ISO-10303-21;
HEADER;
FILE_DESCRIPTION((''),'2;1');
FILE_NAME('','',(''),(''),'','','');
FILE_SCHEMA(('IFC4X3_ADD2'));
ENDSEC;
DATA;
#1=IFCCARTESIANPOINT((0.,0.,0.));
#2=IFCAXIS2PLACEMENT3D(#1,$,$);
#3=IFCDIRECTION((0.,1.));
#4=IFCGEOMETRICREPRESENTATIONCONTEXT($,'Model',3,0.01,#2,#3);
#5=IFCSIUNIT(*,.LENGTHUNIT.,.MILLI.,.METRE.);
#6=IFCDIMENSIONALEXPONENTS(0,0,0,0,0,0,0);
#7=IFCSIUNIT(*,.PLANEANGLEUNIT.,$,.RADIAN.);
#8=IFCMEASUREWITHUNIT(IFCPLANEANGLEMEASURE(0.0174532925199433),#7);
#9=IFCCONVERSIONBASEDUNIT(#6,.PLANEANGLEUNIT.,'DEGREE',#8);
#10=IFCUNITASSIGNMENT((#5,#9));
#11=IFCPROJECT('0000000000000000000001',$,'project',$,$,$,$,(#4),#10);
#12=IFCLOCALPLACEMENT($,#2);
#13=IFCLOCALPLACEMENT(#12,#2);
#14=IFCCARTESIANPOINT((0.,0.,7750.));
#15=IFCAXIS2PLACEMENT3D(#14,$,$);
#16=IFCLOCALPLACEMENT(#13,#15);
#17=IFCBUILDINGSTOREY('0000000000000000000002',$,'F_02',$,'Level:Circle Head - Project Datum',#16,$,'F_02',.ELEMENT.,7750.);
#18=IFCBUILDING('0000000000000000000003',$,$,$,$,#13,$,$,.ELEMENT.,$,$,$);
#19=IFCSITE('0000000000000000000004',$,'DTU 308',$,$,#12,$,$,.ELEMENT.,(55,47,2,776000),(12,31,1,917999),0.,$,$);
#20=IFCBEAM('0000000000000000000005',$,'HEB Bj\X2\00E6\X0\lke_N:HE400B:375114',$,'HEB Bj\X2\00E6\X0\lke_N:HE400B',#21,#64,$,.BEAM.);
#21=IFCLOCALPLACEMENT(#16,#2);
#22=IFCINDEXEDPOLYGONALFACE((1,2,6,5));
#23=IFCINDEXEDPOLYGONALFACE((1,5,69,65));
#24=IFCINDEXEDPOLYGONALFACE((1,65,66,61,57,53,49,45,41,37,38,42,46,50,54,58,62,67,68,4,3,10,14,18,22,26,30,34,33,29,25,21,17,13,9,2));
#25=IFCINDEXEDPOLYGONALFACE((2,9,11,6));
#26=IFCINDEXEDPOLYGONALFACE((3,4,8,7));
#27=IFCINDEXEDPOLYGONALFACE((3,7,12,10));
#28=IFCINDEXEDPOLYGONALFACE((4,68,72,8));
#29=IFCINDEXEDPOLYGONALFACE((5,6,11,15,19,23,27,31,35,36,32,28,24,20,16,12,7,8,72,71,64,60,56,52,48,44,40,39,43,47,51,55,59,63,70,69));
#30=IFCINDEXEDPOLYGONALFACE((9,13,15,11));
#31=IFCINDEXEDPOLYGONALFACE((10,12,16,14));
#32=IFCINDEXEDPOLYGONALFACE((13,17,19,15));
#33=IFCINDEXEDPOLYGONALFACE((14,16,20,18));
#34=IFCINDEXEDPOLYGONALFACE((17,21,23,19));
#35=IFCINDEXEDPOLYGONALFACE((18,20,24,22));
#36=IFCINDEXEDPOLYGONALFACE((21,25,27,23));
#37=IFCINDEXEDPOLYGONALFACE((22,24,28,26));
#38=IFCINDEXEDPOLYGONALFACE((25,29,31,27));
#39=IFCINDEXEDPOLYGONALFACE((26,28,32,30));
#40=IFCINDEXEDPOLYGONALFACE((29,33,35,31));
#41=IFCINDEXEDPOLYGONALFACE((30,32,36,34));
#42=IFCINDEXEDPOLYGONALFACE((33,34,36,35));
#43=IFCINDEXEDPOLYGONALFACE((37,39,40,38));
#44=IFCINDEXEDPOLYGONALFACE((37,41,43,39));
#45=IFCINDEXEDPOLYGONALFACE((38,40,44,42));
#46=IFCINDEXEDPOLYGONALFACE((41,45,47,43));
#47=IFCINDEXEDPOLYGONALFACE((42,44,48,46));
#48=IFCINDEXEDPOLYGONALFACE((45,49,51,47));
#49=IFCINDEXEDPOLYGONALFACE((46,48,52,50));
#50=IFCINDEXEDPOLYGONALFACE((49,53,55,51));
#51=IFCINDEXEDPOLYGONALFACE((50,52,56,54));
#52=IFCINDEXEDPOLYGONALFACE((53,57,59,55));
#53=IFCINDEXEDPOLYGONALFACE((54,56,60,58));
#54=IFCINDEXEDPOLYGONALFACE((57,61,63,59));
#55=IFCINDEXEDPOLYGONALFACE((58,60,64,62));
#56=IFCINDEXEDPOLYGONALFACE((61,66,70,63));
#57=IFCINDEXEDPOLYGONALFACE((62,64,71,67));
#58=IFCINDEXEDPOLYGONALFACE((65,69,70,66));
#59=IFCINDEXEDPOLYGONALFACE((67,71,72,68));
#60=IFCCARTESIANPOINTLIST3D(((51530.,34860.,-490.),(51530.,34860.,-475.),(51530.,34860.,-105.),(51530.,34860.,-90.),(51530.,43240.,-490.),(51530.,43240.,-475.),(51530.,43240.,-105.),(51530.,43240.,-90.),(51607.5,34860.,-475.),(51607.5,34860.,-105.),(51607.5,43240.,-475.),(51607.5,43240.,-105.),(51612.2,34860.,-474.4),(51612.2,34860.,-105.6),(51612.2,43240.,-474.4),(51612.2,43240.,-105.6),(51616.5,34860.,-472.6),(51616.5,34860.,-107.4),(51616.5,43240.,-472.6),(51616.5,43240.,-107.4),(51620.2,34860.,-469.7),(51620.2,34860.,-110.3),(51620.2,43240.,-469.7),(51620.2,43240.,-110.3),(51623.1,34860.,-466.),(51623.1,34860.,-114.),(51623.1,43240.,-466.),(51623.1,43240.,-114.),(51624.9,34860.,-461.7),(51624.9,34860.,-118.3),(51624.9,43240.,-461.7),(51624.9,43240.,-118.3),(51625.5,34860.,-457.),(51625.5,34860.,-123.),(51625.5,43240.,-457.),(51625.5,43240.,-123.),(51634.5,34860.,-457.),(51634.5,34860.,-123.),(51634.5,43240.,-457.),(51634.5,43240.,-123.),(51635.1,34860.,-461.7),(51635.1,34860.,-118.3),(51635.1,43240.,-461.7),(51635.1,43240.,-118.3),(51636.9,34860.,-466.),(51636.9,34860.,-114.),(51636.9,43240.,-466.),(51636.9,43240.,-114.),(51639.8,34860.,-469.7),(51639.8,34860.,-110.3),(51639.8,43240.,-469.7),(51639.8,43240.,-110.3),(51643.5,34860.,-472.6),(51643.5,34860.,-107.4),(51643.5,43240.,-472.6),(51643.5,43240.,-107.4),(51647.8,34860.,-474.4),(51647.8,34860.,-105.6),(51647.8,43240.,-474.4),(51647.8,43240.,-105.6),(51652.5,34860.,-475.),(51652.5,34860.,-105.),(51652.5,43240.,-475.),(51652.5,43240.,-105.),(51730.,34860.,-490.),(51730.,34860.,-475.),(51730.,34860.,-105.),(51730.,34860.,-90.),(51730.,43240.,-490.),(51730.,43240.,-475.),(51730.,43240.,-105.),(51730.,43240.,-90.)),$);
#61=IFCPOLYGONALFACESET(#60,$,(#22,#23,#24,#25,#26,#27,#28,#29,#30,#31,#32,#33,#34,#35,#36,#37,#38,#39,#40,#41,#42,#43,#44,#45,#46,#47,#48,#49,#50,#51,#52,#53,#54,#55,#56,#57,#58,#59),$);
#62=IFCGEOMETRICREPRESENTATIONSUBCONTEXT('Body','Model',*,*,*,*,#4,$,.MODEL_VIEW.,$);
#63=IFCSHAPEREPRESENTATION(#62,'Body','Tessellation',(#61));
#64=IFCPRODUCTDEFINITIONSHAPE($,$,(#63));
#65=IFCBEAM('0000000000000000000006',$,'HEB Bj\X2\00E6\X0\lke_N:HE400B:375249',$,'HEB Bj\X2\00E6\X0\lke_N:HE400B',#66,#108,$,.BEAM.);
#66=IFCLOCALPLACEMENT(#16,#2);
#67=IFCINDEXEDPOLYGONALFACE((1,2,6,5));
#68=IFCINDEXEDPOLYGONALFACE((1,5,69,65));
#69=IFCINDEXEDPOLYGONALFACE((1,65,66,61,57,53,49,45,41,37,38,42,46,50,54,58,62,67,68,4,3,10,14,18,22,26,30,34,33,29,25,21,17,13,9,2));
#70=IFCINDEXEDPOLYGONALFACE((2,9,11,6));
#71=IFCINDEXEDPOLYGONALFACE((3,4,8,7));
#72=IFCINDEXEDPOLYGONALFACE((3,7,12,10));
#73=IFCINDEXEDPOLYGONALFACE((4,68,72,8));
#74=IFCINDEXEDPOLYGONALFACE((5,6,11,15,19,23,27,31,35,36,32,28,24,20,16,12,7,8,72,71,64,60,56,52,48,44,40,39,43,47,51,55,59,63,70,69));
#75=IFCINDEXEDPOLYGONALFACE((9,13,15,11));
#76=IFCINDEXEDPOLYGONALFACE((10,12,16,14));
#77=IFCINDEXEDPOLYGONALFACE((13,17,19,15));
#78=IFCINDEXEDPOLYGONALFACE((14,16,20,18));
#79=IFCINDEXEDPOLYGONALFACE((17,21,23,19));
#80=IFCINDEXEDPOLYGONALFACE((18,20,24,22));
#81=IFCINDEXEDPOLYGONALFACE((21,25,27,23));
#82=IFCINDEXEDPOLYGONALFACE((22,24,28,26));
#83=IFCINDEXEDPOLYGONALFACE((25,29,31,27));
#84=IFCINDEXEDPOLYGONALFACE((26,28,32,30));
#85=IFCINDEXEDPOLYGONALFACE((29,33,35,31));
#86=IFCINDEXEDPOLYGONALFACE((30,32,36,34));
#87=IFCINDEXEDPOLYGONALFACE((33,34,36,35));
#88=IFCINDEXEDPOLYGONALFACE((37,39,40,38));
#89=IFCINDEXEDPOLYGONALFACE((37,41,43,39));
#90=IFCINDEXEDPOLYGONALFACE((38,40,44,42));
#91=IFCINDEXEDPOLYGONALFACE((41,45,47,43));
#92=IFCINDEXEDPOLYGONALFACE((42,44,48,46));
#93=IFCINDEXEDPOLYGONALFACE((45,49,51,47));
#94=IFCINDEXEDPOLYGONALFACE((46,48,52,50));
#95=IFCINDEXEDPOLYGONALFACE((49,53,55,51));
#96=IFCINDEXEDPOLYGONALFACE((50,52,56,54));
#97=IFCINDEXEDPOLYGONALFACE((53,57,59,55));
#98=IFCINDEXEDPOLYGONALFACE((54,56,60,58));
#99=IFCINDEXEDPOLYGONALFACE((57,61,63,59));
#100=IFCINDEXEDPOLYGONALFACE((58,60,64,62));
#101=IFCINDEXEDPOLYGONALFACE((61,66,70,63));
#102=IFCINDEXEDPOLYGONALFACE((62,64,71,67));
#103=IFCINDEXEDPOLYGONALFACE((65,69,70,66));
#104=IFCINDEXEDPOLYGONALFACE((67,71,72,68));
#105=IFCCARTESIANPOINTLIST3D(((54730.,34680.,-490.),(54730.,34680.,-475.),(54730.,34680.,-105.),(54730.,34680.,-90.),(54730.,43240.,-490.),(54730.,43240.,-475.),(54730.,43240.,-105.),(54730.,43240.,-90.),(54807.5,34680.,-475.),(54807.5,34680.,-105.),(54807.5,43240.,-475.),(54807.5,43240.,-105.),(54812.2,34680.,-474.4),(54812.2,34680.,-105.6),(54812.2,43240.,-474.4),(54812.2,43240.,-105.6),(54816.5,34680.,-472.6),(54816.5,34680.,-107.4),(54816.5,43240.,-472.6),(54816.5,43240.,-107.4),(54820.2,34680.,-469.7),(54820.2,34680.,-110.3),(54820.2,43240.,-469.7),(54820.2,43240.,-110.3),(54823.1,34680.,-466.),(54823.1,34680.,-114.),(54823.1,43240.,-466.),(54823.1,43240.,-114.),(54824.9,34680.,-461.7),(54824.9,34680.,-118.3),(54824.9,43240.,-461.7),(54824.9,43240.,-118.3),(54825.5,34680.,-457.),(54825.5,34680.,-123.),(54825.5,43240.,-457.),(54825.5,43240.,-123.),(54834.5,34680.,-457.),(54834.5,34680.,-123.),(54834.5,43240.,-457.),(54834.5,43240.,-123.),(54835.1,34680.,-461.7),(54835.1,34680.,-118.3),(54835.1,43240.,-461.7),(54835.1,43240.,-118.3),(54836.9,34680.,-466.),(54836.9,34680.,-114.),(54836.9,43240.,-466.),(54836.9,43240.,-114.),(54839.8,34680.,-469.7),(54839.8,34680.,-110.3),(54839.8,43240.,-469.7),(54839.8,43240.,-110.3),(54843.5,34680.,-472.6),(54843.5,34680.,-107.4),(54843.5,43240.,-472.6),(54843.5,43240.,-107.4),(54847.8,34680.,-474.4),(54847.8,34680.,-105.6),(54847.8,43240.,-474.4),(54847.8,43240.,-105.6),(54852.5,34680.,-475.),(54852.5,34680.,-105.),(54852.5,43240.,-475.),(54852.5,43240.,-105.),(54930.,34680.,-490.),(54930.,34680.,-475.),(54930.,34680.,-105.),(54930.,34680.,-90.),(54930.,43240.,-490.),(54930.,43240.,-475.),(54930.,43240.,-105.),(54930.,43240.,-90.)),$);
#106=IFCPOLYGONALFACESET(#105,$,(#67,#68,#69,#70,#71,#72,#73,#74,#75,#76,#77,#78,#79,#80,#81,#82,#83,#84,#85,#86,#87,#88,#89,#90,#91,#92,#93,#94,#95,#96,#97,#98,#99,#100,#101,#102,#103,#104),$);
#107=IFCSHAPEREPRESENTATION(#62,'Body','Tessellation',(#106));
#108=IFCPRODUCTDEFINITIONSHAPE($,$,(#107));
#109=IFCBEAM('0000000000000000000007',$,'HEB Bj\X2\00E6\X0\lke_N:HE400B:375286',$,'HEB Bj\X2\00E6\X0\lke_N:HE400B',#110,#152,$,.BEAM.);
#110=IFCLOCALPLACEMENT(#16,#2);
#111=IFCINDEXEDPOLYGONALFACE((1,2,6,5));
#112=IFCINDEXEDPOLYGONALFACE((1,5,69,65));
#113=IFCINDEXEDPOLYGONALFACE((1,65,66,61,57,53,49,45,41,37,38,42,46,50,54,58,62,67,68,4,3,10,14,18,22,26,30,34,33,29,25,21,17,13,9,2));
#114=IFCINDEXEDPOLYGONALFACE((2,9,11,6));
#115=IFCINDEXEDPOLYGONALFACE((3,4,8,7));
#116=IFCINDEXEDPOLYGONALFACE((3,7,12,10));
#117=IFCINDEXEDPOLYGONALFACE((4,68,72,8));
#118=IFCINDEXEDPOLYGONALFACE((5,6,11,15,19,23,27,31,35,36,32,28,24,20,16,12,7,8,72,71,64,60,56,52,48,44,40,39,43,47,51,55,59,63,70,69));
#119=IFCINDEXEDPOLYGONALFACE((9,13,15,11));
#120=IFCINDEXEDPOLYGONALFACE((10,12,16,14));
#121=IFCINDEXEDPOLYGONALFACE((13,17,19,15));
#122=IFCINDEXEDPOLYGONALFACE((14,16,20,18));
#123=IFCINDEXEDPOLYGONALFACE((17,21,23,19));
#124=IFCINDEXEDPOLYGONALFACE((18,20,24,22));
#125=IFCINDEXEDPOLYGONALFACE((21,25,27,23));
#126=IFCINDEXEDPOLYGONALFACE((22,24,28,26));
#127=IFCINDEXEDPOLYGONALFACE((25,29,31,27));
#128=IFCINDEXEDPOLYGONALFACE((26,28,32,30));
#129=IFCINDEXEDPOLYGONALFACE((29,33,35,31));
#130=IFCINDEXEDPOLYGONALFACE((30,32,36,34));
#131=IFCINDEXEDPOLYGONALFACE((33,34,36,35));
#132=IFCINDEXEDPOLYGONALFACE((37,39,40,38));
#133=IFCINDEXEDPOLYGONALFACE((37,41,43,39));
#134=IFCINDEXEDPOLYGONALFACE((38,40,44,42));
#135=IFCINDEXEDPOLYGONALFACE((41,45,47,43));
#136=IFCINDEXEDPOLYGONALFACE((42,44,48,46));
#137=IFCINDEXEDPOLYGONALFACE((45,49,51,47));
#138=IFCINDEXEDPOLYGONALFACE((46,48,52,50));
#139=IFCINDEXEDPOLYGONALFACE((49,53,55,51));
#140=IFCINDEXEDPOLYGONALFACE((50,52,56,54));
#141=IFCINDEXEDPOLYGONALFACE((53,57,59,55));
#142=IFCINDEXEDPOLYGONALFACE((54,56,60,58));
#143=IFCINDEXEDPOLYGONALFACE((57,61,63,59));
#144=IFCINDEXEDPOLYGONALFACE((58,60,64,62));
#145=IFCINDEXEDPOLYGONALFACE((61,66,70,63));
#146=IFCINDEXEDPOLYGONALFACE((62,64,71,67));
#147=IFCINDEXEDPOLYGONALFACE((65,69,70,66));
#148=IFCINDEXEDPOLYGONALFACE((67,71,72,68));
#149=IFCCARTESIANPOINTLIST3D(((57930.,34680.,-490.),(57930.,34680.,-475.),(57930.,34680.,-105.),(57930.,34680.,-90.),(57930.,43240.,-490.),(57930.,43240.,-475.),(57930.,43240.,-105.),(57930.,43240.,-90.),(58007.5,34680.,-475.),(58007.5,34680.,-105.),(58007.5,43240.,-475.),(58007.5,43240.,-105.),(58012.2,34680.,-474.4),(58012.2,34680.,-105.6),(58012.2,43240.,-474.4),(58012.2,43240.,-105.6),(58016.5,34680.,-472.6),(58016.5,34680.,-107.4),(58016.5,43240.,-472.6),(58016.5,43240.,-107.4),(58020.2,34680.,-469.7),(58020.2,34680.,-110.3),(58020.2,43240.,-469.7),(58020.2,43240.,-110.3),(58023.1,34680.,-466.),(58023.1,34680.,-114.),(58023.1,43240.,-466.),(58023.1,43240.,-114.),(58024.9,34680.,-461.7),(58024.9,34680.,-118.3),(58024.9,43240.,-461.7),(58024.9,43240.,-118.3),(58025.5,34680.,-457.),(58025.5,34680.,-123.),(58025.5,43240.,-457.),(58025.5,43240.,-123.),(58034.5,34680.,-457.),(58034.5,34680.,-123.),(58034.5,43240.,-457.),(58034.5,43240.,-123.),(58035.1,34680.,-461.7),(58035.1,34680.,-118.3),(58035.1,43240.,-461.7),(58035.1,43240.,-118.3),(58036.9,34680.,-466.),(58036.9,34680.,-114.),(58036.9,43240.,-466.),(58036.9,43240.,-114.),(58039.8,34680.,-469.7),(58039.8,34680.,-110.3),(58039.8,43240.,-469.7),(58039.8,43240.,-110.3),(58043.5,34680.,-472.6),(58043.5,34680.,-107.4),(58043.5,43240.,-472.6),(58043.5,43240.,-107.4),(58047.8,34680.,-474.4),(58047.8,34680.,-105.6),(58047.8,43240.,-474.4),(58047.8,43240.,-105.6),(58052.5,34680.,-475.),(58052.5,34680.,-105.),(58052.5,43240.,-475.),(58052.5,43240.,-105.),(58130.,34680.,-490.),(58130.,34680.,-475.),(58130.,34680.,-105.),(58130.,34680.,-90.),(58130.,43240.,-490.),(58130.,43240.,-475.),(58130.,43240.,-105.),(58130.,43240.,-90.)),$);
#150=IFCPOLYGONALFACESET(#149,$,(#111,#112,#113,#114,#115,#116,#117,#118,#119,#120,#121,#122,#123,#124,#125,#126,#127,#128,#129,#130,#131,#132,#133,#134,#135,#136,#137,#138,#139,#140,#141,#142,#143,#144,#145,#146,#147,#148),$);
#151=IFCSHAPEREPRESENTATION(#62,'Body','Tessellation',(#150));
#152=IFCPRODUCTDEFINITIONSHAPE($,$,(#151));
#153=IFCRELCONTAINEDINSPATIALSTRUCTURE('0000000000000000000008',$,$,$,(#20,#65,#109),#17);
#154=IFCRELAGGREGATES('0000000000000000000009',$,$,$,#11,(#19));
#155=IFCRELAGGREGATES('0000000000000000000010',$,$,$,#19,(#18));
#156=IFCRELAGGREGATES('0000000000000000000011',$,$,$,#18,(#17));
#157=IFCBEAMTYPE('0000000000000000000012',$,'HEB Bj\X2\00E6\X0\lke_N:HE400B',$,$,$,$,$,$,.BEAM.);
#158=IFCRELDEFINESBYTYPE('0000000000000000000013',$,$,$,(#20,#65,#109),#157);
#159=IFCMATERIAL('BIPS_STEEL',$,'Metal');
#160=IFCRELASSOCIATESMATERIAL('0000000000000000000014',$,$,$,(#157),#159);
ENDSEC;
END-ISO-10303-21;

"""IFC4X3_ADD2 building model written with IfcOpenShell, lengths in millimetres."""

from ifc_helpers import new_model, entity, si_unit, converted_unit, direction, frame, frame_2d, origin, place, context, subcontext, project, spatial, polyline, circle_curve, parameter, trimmed, segment, composite_curve, outline, extrude, source, transform, mapped, material, material_profile, profile_set, type_object, element, save


model = new_model("IFC4X3_ADD2")

# Units and contexts
model_context = context("Model", 3, precision=0.01, world=origin(), true_north=direction((0.0, 1.0)))
body_context = subcontext(model_context, "Body", "Model", "MODEL_VIEW")
ifc_project = project(units=[si_unit("LENGTHUNIT", "METRE", prefix="MILLI"), converted_unit("PLANEANGLEUNIT", "DEGREE", entity("IfcPlaneAngleMeasure", 0.0174532925199433), si_unit("PLANEANGLEUNIT", "RADIAN"), dimensions=[0, 0, 0, 0, 0, 0, 0])], contexts=[model_context])

# Site, building, storey
site_placement = place(None, origin())
site = spatial("IfcSite", under=ifc_project, at=site_placement, Name="DTU 308", CompositionType="ELEMENT", RefLatitude=(55, 47, 2, 776000), RefLongitude=(12, 31, 1, 917999), RefElevation=0.0)
building_placement = place(site_placement, origin())
building = spatial("IfcBuilding", under=site, at=building_placement, CompositionType="ELEMENT")
storey_placement = place(building_placement, frame((0.0, 0.0, 7750.0)))
storey = spatial("IfcBuildingStorey", under=building, at=storey_placement, Name="F_02", ObjectType="Level:Circle Head - Project Datum", LongName="F_02", CompositionType="ELEMENT", Elevation=7750.0)

# Shared definitions
ifc_material = material(Name="BIPS_STEEL", Category="Metal")

# Beams
ifc_material_profile_1 = material_profile(ifc_material, outline(composite_curve([segment(polyline([(-100.0, -185.0), (-100.0, -200.0)]), True, "CONTINUOUS"), segment(polyline([(-100.0, -200.0), (100.0, -200.0)]), True, "CONTINUOUS"), segment(polyline([(100.0, -200.0), (100.0, -185.0)]), True, "CONTINUOUS"), segment(polyline([(100.0, -185.0), (22.5, -185.0)]), True, "CONTINUOUS"), segment(trimmed(circle_curve(frame_2d((22.5, -167.0), x_axis=(1.0, 0.0)), 18.0), [parameter(180.0)], [parameter(270.0)], True, "PARAMETER"), False, "CONTINUOUS"), segment(polyline([(4.5, -167.0), (4.5, 167.0)]), True, "CONTINUOUS"), segment(trimmed(circle_curve(frame_2d((22.5, 167.0), x_axis=(1.0, 0.0)), 18.0), [parameter(90.0)], [parameter(180.0)], True, "PARAMETER"), False, "CONTINUOUS"), segment(polyline([(22.5, 185.0), (100.0, 185.0)]), True, "CONTINUOUS"), segment(polyline([(100.0, 185.0), (100.0, 200.0)]), True, "CONTINUOUS"), segment(polyline([(100.0, 200.0), (-100.0, 200.0)]), True, "CONTINUOUS"), segment(polyline([(-100.0, 200.0), (-100.0, 185.0)]), True, "CONTINUOUS"), segment(polyline([(-100.0, 185.0), (-22.5, 185.0)]), True, "CONTINUOUS"), segment(trimmed(circle_curve(frame_2d((-22.5, 167.0), x_axis=(1.0, 0.0)), 18.0), [parameter(360.0)], [parameter(90.0)], True, "PARAMETER"), False, "CONTINUOUS"), segment(polyline([(-4.5, 167.0), (-4.5, -167.0)]), True, "CONTINUOUS"), segment(trimmed(circle_curve(frame_2d((-22.5, -167.0), x_axis=(1.0, 0.0)), 18.0), [parameter(270.0)], [parameter(360.0)], True, "PARAMETER"), False, "CONTINUOUS"), segment(polyline([(-22.5, -185.0), (-100.0, -185.0)]), True, "CONTINUOUS")], self_intersect=False)), Name="HE400B")
ifc_profile_set_1 = profile_set([ifc_material_profile_1], Name="HE400B")
beam_type_1 = type_object("IfcBeamType", Name="HEB Bjælke_N:HE400B", PredefinedType="BEAM", material=ifc_profile_set_1)
shared_shape_1 = source(origin(), body_context, "Body", "SweptSolid", [
    extrude(outline(composite_curve([segment(polyline([(-100.0, -185.0), (-100.0, -200.0)]), True, "CONTINUOUS"), segment(polyline([(-100.0, -200.0), (100.0, -200.0)]), True, "CONTINUOUS"), segment(polyline([(100.0, -200.0), (100.0, -185.0)]), True, "CONTINUOUS"), segment(polyline([(100.0, -185.0), (22.5, -185.0)]), True, "CONTINUOUS"), segment(trimmed(circle_curve(frame_2d((22.5, -167.0), x_axis=(1.0, 0.0)), 18.0), [parameter(180.0)], [parameter(270.0)], True, "PARAMETER"), False, "CONTINUOUS"), segment(polyline([(4.5, -167.0), (4.5, 167.0)]), True, "CONTINUOUS"), segment(trimmed(circle_curve(frame_2d((22.5, 167.0), x_axis=(1.0, 0.0)), 18.0), [parameter(90.0)], [parameter(180.0)], True, "PARAMETER"), False, "CONTINUOUS"), segment(polyline([(22.5, 185.0), (100.0, 185.0)]), True, "CONTINUOUS"), segment(polyline([(100.0, 185.0), (100.0, 200.0)]), True, "CONTINUOUS"), segment(polyline([(100.0, 200.0), (-100.0, 200.0)]), True, "CONTINUOUS"), segment(polyline([(-100.0, 200.0), (-100.0, 185.0)]), True, "CONTINUOUS"), segment(polyline([(-100.0, 185.0), (-22.5, 185.0)]), True, "CONTINUOUS"), segment(trimmed(circle_curve(frame_2d((-22.5, 167.0), x_axis=(1.0, 0.0)), 18.0), [parameter(360.0)], [parameter(90.0)], True, "PARAMETER"), False, "CONTINUOUS"), segment(polyline([(-4.5, 167.0), (-4.5, -167.0)]), True, "CONTINUOUS"), segment(trimmed(circle_curve(frame_2d((-22.5, -167.0), x_axis=(1.0, 0.0)), 18.0), [parameter(270.0)], [parameter(360.0)], True, "PARAMETER"), False, "CONTINUOUS"), segment(polyline([(-22.5, -185.0), (-100.0, -185.0)]), True, "CONTINUOUS")], self_intersect=False)), frame((-5880.0, 0.0, 0.0), z_axis=(-1.0, 0.0, 0.0), x_axis=(0.0, -1.0, 0.0)), (0.0, 0.0, -1.0), 8380.0),
])
beam_1_placement = place(storey_placement, frame((51630.0, 37360.0, -290.0), z_axis=(0.0, 0.0, 1.0), x_axis=(0.0, -1.0, 0.0)))
element("IfcBeam", 1, at=beam_1_placement, inside=storey, type_object=beam_type_1, Name="HEB Bjælke_N:HE400B:375114", ObjectType="HEB Bjælke_N:HE400B", PredefinedType="BEAM", context=body_context, shape_type="MappedRepresentation", body=[
    mapped(shared_shape_1, transform((0.0, 0.0, 0.0), scale=1.0)),
])
shared_shape_2 = source(origin(), body_context, "Body", "SweptSolid", [
    extrude(outline(composite_curve([segment(polyline([(-100.0, -185.0), (-100.0, -200.0)]), True, "CONTINUOUS"), segment(polyline([(-100.0, -200.0), (100.0, -200.0)]), True, "CONTINUOUS"), segment(polyline([(100.0, -200.0), (100.0, -185.0)]), True, "CONTINUOUS"), segment(polyline([(100.0, -185.0), (22.5, -185.0)]), True, "CONTINUOUS"), segment(trimmed(circle_curve(frame_2d((22.5, -167.0), x_axis=(1.0, 0.0)), 18.0), [parameter(180.0)], [parameter(270.0)], True, "PARAMETER"), False, "CONTINUOUS"), segment(polyline([(4.5, -167.0), (4.5, 167.0)]), True, "CONTINUOUS"), segment(trimmed(circle_curve(frame_2d((22.5, 167.0), x_axis=(1.0, 0.0)), 18.0), [parameter(90.0)], [parameter(180.0)], True, "PARAMETER"), False, "CONTINUOUS"), segment(polyline([(22.5, 185.0), (100.0, 185.0)]), True, "CONTINUOUS"), segment(polyline([(100.0, 185.0), (100.0, 200.0)]), True, "CONTINUOUS"), segment(polyline([(100.0, 200.0), (-100.0, 200.0)]), True, "CONTINUOUS"), segment(polyline([(-100.0, 200.0), (-100.0, 185.0)]), True, "CONTINUOUS"), segment(polyline([(-100.0, 185.0), (-22.5, 185.0)]), True, "CONTINUOUS"), segment(trimmed(circle_curve(frame_2d((-22.5, 167.0), x_axis=(1.0, 0.0)), 18.0), [parameter(360.0)], [parameter(90.0)], True, "PARAMETER"), False, "CONTINUOUS"), segment(polyline([(-4.5, 167.0), (-4.5, -167.0)]), True, "CONTINUOUS"), segment(trimmed(circle_curve(frame_2d((-22.5, -167.0), x_axis=(1.0, 0.0)), 18.0), [parameter(270.0)], [parameter(360.0)], True, "PARAMETER"), False, "CONTINUOUS"), segment(polyline([(-22.5, -185.0), (-100.0, -185.0)]), True, "CONTINUOUS")], self_intersect=False)), frame((-4280.0, 0.0, 0.0), z_axis=(-1.0, 0.0, 0.0), x_axis=(0.0, -1.0, 0.0)), (0.0, 0.0, -1.0), 8560.0),
])
for number, where, z_axis, x_axis, name in (
    (2, (54830.0, 38960.0, -290.0), (0.0, 0.0, 1.0), (0.0, -1.0, 0.0), "HEB Bjælke_N:HE400B:375249"),
    (3, (58030.0, 38960.0, -290.0), (0.0, 0.0, 1.0), (0.0, -1.0, 0.0), "HEB Bjælke_N:HE400B:375286"),
):
    element("IfcBeam", number, at=place(storey_placement, frame(where, z_axis=z_axis, x_axis=x_axis)), inside=storey, type_object=beam_type_1, Name=name, ObjectType="HEB Bjælke_N:HE400B", PredefinedType="BEAM", context=body_context, shape_type="MappedRepresentation", body=[
        mapped(shared_shape_2, transform((0.0, 0.0, 0.0), scale=1.0)),
    ])

save(model, "model.ifc")
